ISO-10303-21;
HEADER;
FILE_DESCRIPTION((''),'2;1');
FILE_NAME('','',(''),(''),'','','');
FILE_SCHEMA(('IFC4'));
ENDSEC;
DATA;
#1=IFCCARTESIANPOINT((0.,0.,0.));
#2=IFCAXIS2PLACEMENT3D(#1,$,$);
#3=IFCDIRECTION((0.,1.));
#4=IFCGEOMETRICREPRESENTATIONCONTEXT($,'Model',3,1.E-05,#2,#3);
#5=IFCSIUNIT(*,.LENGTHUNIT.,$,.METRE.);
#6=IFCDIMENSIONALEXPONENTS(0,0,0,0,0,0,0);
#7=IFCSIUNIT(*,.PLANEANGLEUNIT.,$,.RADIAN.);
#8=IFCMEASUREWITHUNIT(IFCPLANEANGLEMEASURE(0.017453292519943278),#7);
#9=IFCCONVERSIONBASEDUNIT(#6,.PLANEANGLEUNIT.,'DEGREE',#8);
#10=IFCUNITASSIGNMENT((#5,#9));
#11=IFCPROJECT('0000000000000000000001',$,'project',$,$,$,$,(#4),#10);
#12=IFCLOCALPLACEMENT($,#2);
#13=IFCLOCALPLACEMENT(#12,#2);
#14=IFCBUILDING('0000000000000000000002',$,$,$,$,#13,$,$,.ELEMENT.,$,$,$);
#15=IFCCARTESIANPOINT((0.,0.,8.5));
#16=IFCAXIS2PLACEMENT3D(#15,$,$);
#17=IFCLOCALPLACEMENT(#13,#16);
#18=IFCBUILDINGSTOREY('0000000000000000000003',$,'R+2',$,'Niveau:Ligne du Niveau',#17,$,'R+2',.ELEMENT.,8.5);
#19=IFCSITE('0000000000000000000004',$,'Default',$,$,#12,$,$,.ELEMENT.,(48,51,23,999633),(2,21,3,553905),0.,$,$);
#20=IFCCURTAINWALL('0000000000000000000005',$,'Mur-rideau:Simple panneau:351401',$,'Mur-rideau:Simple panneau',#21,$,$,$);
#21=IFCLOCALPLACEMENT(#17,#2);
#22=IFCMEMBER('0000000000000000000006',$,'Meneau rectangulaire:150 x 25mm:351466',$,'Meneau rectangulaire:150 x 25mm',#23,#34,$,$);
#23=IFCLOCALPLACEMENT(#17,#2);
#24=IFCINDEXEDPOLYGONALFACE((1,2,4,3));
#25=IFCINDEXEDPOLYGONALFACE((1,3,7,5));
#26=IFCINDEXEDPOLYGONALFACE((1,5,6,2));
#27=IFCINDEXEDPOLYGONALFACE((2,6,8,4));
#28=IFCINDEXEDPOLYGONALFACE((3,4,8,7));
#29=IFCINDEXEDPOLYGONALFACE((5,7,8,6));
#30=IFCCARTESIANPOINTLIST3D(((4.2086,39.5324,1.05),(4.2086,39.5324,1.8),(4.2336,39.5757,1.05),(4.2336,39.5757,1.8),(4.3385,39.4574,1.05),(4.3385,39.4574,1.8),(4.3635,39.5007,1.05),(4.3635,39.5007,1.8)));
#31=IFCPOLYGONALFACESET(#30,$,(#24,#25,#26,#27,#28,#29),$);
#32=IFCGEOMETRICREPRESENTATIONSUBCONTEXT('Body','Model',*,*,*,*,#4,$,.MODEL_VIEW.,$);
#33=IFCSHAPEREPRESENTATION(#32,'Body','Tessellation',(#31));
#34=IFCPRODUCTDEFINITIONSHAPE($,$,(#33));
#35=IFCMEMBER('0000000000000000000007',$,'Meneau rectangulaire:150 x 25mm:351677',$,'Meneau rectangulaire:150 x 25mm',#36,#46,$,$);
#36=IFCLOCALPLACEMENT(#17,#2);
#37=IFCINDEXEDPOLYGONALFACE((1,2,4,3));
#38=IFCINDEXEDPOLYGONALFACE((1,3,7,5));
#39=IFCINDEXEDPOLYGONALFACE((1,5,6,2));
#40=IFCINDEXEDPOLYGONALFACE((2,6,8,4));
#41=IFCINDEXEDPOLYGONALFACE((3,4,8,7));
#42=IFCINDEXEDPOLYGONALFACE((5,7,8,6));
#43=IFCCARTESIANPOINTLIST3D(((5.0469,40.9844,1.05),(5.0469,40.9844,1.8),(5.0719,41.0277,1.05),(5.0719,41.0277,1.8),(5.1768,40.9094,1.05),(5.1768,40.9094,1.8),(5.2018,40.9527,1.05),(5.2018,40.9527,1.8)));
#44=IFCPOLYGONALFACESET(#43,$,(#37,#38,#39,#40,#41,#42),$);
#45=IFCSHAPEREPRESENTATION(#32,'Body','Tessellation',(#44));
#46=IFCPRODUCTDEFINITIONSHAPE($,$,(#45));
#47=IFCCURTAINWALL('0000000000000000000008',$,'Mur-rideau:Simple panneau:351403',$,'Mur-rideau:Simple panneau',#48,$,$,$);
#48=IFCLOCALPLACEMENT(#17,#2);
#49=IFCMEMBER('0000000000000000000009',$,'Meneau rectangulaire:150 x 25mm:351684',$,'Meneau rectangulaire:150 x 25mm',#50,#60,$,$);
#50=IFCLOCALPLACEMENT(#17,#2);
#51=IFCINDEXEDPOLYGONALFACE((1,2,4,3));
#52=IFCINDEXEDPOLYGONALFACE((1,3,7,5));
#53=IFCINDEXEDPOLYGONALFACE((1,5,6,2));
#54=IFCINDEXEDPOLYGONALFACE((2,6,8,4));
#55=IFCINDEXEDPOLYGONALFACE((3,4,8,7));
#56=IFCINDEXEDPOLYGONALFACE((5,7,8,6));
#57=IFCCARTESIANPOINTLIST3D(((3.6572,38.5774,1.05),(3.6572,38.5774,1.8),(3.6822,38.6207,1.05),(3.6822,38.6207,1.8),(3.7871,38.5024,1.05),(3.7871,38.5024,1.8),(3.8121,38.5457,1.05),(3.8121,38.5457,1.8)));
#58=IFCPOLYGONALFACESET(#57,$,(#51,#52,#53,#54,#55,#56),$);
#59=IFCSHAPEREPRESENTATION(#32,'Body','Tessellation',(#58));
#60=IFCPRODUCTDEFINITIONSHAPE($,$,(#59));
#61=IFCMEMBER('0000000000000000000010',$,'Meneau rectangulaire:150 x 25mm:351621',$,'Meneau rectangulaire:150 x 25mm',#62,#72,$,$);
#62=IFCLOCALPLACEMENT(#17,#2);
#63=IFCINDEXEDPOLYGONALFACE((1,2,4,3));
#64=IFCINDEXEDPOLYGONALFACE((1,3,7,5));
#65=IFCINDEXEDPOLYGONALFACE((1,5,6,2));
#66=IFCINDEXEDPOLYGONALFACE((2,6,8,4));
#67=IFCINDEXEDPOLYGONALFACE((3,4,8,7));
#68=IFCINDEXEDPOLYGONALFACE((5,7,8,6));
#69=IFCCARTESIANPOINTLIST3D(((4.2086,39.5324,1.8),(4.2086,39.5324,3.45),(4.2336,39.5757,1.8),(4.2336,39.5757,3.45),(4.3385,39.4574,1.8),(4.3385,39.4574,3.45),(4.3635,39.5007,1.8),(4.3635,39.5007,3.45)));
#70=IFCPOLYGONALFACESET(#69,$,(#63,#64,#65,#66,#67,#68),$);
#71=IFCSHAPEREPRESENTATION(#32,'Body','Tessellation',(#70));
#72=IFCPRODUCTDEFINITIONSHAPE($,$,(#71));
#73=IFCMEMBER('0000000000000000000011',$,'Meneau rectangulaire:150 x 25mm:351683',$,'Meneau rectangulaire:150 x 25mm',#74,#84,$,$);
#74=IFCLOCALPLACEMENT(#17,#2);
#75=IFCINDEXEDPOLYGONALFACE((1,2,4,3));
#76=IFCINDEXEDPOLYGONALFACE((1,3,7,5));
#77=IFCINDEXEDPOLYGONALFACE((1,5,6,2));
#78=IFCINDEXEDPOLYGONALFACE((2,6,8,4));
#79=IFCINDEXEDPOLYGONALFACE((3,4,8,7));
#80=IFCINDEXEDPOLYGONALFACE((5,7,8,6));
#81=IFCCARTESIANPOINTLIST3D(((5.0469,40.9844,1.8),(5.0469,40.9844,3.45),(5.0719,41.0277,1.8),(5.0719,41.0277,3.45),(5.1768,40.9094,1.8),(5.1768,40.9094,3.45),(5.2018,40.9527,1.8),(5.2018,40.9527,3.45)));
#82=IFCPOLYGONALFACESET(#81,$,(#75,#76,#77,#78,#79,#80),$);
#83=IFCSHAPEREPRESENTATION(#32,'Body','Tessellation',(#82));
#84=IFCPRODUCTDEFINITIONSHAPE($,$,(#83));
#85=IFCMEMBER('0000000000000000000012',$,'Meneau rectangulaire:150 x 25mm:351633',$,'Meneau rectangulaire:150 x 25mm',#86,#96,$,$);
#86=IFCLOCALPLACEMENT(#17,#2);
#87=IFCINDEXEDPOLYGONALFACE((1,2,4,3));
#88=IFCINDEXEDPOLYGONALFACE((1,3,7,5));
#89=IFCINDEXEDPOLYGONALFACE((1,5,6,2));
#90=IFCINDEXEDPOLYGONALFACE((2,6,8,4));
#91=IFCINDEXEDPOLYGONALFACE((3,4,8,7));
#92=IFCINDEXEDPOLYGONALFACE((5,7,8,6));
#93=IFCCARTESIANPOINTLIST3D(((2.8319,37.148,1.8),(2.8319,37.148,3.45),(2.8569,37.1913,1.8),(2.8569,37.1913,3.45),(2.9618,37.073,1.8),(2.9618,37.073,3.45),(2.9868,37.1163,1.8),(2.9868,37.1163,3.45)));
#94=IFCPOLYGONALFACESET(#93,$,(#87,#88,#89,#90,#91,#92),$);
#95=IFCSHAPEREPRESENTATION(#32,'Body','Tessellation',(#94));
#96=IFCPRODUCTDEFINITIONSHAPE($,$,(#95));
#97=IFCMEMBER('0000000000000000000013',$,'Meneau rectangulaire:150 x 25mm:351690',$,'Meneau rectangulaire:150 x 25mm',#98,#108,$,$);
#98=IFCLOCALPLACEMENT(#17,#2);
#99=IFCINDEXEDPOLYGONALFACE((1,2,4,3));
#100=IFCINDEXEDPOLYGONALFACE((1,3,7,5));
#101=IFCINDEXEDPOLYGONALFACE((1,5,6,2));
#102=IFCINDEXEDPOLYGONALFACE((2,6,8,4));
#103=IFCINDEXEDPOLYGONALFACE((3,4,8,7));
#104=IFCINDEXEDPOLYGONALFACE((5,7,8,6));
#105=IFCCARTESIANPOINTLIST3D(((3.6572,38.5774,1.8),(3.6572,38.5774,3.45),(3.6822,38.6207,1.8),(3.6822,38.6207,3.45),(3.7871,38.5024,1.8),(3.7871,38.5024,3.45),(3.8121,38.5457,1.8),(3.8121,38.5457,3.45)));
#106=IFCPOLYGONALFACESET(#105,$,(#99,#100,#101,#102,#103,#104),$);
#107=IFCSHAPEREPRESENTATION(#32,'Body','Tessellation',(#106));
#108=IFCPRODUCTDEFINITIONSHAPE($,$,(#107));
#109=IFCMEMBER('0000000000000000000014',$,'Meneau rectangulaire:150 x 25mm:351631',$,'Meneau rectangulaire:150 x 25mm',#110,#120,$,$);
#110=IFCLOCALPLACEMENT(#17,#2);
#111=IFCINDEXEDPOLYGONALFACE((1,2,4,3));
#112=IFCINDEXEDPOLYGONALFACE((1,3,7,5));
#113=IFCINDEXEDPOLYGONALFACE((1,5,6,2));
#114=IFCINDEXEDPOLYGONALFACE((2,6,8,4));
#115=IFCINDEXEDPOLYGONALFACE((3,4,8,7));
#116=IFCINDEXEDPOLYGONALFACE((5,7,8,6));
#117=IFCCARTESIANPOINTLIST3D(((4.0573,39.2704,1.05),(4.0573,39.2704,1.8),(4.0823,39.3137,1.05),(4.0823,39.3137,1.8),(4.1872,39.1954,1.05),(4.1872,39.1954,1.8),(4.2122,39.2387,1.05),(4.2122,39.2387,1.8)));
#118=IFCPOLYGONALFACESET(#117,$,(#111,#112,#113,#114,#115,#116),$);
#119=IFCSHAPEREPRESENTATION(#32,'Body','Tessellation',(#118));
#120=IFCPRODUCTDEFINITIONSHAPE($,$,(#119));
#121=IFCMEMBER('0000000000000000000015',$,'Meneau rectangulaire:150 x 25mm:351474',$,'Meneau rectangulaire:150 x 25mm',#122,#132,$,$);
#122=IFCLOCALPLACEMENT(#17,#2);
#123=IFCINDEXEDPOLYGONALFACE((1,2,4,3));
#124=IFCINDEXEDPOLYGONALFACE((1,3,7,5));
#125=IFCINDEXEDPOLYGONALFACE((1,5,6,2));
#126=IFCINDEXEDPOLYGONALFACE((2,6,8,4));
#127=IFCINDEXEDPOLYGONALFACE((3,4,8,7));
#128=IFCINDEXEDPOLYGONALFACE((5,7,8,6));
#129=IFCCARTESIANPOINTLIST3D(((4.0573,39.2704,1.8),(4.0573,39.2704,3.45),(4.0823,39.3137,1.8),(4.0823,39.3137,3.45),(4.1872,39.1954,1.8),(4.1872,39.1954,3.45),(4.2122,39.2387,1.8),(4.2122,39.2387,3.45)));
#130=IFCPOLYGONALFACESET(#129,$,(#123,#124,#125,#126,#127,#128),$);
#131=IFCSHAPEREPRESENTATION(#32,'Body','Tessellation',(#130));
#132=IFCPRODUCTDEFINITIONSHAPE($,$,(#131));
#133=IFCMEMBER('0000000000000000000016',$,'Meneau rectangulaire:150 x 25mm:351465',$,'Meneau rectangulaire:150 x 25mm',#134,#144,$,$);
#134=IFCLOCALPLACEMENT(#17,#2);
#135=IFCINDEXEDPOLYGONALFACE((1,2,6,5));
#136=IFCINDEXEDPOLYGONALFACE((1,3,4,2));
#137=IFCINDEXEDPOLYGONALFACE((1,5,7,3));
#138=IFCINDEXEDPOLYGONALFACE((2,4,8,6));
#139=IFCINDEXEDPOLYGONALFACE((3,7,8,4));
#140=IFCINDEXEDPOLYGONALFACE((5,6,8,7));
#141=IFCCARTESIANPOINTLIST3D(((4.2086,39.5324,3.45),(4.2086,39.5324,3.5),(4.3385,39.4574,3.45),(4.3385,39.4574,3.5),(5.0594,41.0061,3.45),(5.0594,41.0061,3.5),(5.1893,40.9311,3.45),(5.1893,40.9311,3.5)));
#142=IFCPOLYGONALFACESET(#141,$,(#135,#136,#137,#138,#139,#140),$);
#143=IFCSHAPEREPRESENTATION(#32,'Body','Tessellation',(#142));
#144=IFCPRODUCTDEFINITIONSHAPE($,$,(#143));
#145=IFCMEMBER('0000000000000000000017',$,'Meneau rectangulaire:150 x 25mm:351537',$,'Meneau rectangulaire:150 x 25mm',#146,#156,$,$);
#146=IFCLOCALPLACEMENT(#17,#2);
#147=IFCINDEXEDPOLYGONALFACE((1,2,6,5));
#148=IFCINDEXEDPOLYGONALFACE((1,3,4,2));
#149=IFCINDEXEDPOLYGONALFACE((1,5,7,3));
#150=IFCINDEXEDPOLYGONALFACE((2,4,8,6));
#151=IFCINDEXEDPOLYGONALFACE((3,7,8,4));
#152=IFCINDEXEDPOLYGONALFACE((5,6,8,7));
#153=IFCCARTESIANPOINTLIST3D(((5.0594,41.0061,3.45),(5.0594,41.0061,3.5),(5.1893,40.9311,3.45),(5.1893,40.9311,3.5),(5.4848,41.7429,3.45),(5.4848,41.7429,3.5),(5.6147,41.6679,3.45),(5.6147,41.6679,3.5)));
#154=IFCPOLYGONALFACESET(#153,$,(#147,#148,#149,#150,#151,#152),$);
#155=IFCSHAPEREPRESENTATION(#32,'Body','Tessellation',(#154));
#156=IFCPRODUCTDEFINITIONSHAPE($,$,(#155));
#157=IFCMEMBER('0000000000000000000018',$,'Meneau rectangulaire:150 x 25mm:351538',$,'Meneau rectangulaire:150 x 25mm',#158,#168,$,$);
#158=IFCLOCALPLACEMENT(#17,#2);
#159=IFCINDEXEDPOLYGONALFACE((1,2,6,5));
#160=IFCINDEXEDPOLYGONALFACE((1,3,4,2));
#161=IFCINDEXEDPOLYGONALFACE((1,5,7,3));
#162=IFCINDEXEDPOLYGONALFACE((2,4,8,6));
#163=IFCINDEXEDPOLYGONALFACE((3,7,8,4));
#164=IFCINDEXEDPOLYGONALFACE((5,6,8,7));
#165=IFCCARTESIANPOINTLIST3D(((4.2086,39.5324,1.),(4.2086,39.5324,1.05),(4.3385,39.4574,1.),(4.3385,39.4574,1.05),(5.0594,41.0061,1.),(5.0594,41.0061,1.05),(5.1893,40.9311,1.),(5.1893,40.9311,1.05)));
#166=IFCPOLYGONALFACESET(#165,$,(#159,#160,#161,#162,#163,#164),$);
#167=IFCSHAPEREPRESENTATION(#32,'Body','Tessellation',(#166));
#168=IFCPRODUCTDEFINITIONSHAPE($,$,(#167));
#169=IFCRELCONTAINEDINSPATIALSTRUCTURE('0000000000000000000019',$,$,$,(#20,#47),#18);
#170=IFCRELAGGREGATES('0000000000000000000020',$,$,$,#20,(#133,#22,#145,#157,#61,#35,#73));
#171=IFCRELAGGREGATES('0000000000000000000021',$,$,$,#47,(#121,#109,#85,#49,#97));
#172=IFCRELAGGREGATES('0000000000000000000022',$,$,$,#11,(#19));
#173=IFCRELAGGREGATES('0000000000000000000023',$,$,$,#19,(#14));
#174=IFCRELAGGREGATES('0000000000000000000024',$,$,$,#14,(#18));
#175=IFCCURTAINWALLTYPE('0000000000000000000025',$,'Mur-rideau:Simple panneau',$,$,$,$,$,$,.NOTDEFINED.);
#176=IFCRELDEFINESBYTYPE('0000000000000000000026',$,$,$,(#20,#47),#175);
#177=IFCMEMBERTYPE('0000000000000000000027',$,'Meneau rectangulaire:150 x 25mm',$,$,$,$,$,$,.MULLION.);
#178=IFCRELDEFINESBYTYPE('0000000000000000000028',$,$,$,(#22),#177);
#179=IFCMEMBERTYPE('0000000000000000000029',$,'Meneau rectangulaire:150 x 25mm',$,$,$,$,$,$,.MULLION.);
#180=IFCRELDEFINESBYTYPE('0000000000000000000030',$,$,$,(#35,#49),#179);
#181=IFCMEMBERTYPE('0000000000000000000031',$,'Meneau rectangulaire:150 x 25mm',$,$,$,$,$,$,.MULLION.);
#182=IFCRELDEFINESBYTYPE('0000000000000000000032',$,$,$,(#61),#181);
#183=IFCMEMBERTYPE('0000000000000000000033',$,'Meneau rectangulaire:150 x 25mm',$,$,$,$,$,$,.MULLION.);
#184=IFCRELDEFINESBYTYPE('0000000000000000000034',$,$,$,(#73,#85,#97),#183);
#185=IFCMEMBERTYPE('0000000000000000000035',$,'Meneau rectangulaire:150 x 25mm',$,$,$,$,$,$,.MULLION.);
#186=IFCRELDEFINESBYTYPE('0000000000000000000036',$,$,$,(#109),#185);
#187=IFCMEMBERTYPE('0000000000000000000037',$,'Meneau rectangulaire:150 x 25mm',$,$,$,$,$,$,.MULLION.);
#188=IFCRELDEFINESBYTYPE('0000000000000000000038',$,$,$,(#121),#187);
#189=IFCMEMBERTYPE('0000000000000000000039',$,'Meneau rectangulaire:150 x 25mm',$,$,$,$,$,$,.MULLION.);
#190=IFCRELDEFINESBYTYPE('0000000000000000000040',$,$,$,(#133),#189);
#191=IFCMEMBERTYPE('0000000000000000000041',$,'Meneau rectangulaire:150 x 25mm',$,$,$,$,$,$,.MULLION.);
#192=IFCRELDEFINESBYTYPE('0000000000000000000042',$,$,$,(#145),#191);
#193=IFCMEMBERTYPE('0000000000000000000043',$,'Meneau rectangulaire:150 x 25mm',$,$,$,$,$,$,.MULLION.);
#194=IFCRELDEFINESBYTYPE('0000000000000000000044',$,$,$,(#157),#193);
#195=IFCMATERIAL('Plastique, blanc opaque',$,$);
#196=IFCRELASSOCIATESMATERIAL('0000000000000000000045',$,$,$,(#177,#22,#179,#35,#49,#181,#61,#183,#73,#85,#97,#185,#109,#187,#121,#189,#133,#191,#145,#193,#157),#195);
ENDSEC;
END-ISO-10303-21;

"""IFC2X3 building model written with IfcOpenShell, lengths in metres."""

from ifc_helpers import new_model, entity, si_unit, converted_unit, direction, frame, frame_2d, origin, origin_2d_with_axis, place, context, subcontext, project, spatial, rectangle, extrude, source, transform, mapped, material, type_object, type_shapes, element, aggregate, save


model = new_model("IFC2X3")

# Units and contexts
model_context = context("Model", 3, precision=1e-05, world=origin(), true_north=direction((0.0, 1.0)))
body_context = subcontext(model_context, "Body", "Model", "MODEL_VIEW")
ifc_project = project(units=[si_unit("LENGTHUNIT", "METRE"), converted_unit("PLANEANGLEUNIT", "DEGREE", entity("IfcPlaneAngleMeasure", 0.017453292519943278), si_unit("PLANEANGLEUNIT", "RADIAN"), dimensions=[0, 0, 0, 0, 0, 0, 0])], contexts=[model_context])

# Site, building, storey
site_placement = place(None, origin())
site = spatial("IfcSite", under=ifc_project, at=site_placement, Name="Default", CompositionType="ELEMENT", RefLatitude=(48, 51, 23, 999633), RefLongitude=(2, 21, 3, 553905), RefElevation=0.0)
building_placement = place(site_placement, origin())
building = spatial("IfcBuilding", under=site, at=building_placement, CompositionType="ELEMENT")
storey_placement = place(building_placement, frame((0.0, 0.0, 8.5)))
storey = spatial("IfcBuildingStorey", under=building, at=storey_placement, Name="R+2", ObjectType="Niveau:Ligne du Niveau", LongName="R+2", CompositionType="ELEMENT", Elevation=8.5)

# Curtain wall, members
curtain_wall_type = type_object("IfcCurtainWallType", Name="Mur-rideau:Simple panneau", PredefinedType="NOTDEFINED")
curtain_wall_1_placement = place(storey_placement, frame((0.0, 0.0, -8.5)))
curtain_wall_1 = element("IfcCurtainWall", 1, at=curtain_wall_1_placement, inside=storey, type_object=curtain_wall_type, Name="Mur-rideau:Simple panneau:351401", ObjectType="Mur-rideau:Simple panneau")
ifc_material_1 = material(Name="Plastique, blanc opaque")
member_type_1 = type_object("IfcMemberType", Name="Meneau rectangulaire:150 x 25mm", PredefinedType="MULLION", material=ifc_material_1)
shared_shape_1 = source(origin(), body_context, "Body", "SweptSolid", [
    extrude(rectangle(XDim=0.05, YDim=0.15, at=origin_2d_with_axis()), frame((-0.025, 0.0, -0.75), z_axis=(0.0, 0.0, 1.0), x_axis=(-1.0, 0.0, 0.0)), (0.0, 0.0, 1.0), 0.75),
])
type_shapes(member_type_1, [shared_shape_1])
member_1_placement = place(curtain_wall_1_placement, frame((4.2735, 39.4949, 9.55), z_axis=(0.0, 0.0, -1.0), x_axis=(-0.5, -0.866025, 0.0)))
member_1 = element("IfcMember", 2, at=member_1_placement, type_object=member_type_1, material=ifc_material_1, Name="Meneau rectangulaire:150 x 25mm:351466", ObjectType="Meneau rectangulaire:150 x 25mm", context=body_context, shape_type="MappedRepresentation", body=[
    mapped(shared_shape_1, transform((0.0, 0.0, 0.0), scale=1.0)),
])
member_type_2 = type_object("IfcMemberType", Name="Meneau rectangulaire:150 x 25mm", PredefinedType="MULLION", material=ifc_material_1)
shared_shape_2 = source(origin(), body_context, "Body", "SweptSolid", [
    extrude(rectangle(XDim=0.05, YDim=0.15, at=origin_2d_with_axis()), frame((0.0, 0.0, -0.75), z_axis=(0.0, 0.0, 1.0), x_axis=(-1.0, 0.0, 0.0)), (0.0, 0.0, 1.0), 0.75),
])
type_shapes(member_type_2, [shared_shape_2])
member_2_placement = place(curtain_wall_1_placement, frame((5.1244, 40.9686, 9.55), z_axis=(0.0, 0.0, -1.0), x_axis=(-0.5, -0.866025, 0.0)))
member_2 = element("IfcMember", 3, at=member_2_placement, type_object=member_type_2, material=ifc_material_1, Name="Meneau rectangulaire:150 x 25mm:351677", ObjectType="Meneau rectangulaire:150 x 25mm", context=body_context, shape_type="MappedRepresentation", body=[
    mapped(shared_shape_2, transform((0.0, 0.0, 0.0), scale=1.0)),
])

# Curtain wall, member
curtain_wall_2_placement = place(storey_placement, frame((0.0, 0.0, -8.5)))
curtain_wall_2 = element("IfcCurtainWall", 4, at=curtain_wall_2_placement, inside=storey, type_object=curtain_wall_type, Name="Mur-rideau:Simple panneau:351403", ObjectType="Mur-rideau:Simple panneau")
member_3_placement = place(curtain_wall_2_placement, frame((3.7347, 38.5615, 9.55), z_axis=(0.0, 0.0, -1.0), x_axis=(-0.5, -0.866025, 0.0)))
member_3 = element("IfcMember", 5, at=member_3_placement, type_object=member_type_2, material=ifc_material_1, Name="Meneau rectangulaire:150 x 25mm:351684", ObjectType="Meneau rectangulaire:150 x 25mm", context=body_context, shape_type="MappedRepresentation", body=[
    mapped(shared_shape_2, transform((0.0, 0.0, 0.0), scale=1.0)),
])

# Members
member_type_3 = type_object("IfcMemberType", Name="Meneau rectangulaire:150 x 25mm", PredefinedType="MULLION", material=ifc_material_1)
shared_shape_3 = source(origin(), body_context, "Body", "SweptSolid", [
    extrude(rectangle(XDim=0.05, YDim=0.15, at=origin_2d_with_axis()), frame((-0.025, 0.0, -1.65), z_axis=(0.0, 0.0, 1.0), x_axis=(-1.0, 0.0, 0.0)), (0.0, 0.0, 1.0), 1.65),
])
type_shapes(member_type_3, [shared_shape_3])
member_4_placement = place(curtain_wall_1_placement, frame((4.2735, 39.4949, 10.3), z_axis=(0.0, 0.0, -1.0), x_axis=(-0.5, -0.866025, 0.0)))
member_4 = element("IfcMember", 6, at=member_4_placement, type_object=member_type_3, material=ifc_material_1, Name="Meneau rectangulaire:150 x 25mm:351621", ObjectType="Meneau rectangulaire:150 x 25mm", context=body_context, shape_type="MappedRepresentation", body=[
    mapped(shared_shape_3, transform((0.0, 0.0, 0.0), scale=1.0)),
])
member_type_4 = type_object("IfcMemberType", Name="Meneau rectangulaire:150 x 25mm", PredefinedType="MULLION", material=ifc_material_1)
shared_shape_4 = source(origin(), body_context, "Body", "SweptSolid", [
    extrude(rectangle(XDim=0.05, YDim=0.15, at=origin_2d_with_axis()), frame((0.0, 0.0, -1.65), z_axis=(0.0, 0.0, 1.0), x_axis=(-1.0, 0.0, 0.0)), (0.0, 0.0, 1.0), 1.65),
])
type_shapes(member_type_4, [shared_shape_4])
member_5_placement = place(curtain_wall_1_placement, frame((5.1244, 40.9686, 10.3), z_axis=(0.0, 0.0, -1.0), x_axis=(-0.5, -0.866025, 0.0)))
member_5 = element("IfcMember", 7, at=member_5_placement, type_object=member_type_4, material=ifc_material_1, Name="Meneau rectangulaire:150 x 25mm:351683", ObjectType="Meneau rectangulaire:150 x 25mm", context=body_context, shape_type="MappedRepresentation", body=[
    mapped(shared_shape_4, transform((0.0, 0.0, 0.0), scale=1.0)),
])
member_6_placement = place(curtain_wall_2_placement, frame((2.9094, 37.1322, 10.3), z_axis=(0.0, 0.0, -1.0), x_axis=(-0.5, -0.866025, 0.0)))
member_6 = element("IfcMember", 8, at=member_6_placement, type_object=member_type_4, material=ifc_material_1, Name="Meneau rectangulaire:150 x 25mm:351633", ObjectType="Meneau rectangulaire:150 x 25mm", context=body_context, shape_type="MappedRepresentation", body=[
    mapped(shared_shape_4, transform((0.0, 0.0, 0.0), scale=1.0)),
])
member_7_placement = place(curtain_wall_2_placement, frame((3.7347, 38.5615, 10.3), z_axis=(0.0, 0.0, -1.0), x_axis=(-0.5, -0.866025, 0.0)))
member_7 = element("IfcMember", 9, at=member_7_placement, type_object=member_type_4, material=ifc_material_1, Name="Meneau rectangulaire:150 x 25mm:351690", ObjectType="Meneau rectangulaire:150 x 25mm", context=body_context, shape_type="MappedRepresentation", body=[
    mapped(shared_shape_4, transform((0.0, 0.0, 0.0), scale=1.0)),
])
member_type_5 = type_object("IfcMemberType", Name="Meneau rectangulaire:150 x 25mm", PredefinedType="MULLION", material=ifc_material_1)
shared_shape_5 = source(origin(), body_context, "Body", "SweptSolid", [
    extrude(rectangle(XDim=0.05, YDim=0.15, at=origin_2d_with_axis()), frame((-0.025, 0.0, -0.75), z_axis=(0.0, 0.0, 1.0), x_axis=(-1.0, 0.0, 0.0)), (0.0, 0.0, 1.0), 0.75),
])
type_shapes(member_type_5, [shared_shape_5])
member_8_placement = place(curtain_wall_2_placement, frame((4.1473, 39.2762, 10.3), z_axis=(0.0, 0.0, 1.0), x_axis=(0.5, 0.866025, 0.0)))
member_8 = element("IfcMember", 10, at=member_8_placement, type_object=member_type_5, material=ifc_material_1, Name="Meneau rectangulaire:150 x 25mm:351631", ObjectType="Meneau rectangulaire:150 x 25mm", context=body_context, shape_type="MappedRepresentation", body=[
    mapped(shared_shape_5, transform((0.0, 0.0, 0.0), scale=1.0)),
])
member_type_6 = type_object("IfcMemberType", Name="Meneau rectangulaire:150 x 25mm", PredefinedType="MULLION", material=ifc_material_1)
shared_shape_6 = source(origin(), body_context, "Body", "SweptSolid", [
    extrude(rectangle(XDim=0.05, YDim=0.15, at=origin_2d_with_axis()), frame((-0.025, 0.0, -1.65), z_axis=(0.0, 0.0, 1.0), x_axis=(-1.0, 0.0, 0.0)), (0.0, 0.0, 1.0), 1.65),
])
type_shapes(member_type_6, [shared_shape_6])
member_9_placement = place(curtain_wall_2_placement, frame((4.1473, 39.2762, 11.95), z_axis=(0.0, 0.0, 1.0), x_axis=(0.5, 0.866025, 0.0)))
member_9 = element("IfcMember", 11, at=member_9_placement, type_object=member_type_6, material=ifc_material_1, Name="Meneau rectangulaire:150 x 25mm:351474", ObjectType="Meneau rectangulaire:150 x 25mm", context=body_context, shape_type="MappedRepresentation", body=[
    mapped(shared_shape_6, transform((0.0, 0.0, 0.0), scale=1.0)),
])
member_type_7 = type_object("IfcMemberType", Name="Meneau rectangulaire:150 x 25mm", PredefinedType="MULLION", material=ifc_material_1)
shared_shape_7 = source(origin(), body_context, "Body", "SweptSolid", [
    extrude(rectangle(XDim=0.05, YDim=0.15, at=frame_2d((0.0, 0.0), x_axis=(1.0, 0.0))), frame((-0.025, 0.0, -1.7017), z_axis=(0.0, 0.0, 1.0), x_axis=(-1.0, 0.0, 0.0)), (0.0, 0.0, 1.0), 1.7017),
])
type_shapes(member_type_7, [shared_shape_7])
member_10_placement = place(curtain_wall_1_placement, frame((4.2735, 39.4949, 12.0), z_axis=(-0.5, -0.866025, 0.0), x_axis=(0.0, 0.0, 1.0)))
member_10 = element("IfcMember", 12, at=member_10_placement, type_object=member_type_7, material=ifc_material_1, Name="Meneau rectangulaire:150 x 25mm:351465", ObjectType="Meneau rectangulaire:150 x 25mm", context=body_context, shape_type="MappedRepresentation", body=[
    mapped(shared_shape_7, transform((0.0, 0.0, 0.0), scale=1.0)),
])
member_type_8 = type_object("IfcMemberType", Name="Meneau rectangulaire:150 x 25mm", PredefinedType="MULLION", material=ifc_material_1)
shared_shape_8 = source(origin(), body_context, "Body", "SweptSolid", [
    extrude(rectangle(XDim=0.05, YDim=0.15, at=origin_2d_with_axis()), frame((-0.025, 0.0, -0.8508), z_axis=(0.0, 0.0, 1.0), x_axis=(-1.0, 0.0, 0.0)), (0.0, 0.0, 1.0), 0.8508),
])
type_shapes(member_type_8, [shared_shape_8])
member_11_placement = place(curtain_wall_1_placement, frame((5.1244, 40.9686, 12.0), z_axis=(-0.5, -0.866025, 0.0), x_axis=(0.0, 0.0, 1.0)))
member_11 = element("IfcMember", 13, at=member_11_placement, type_object=member_type_8, material=ifc_material_1, Name="Meneau rectangulaire:150 x 25mm:351537", ObjectType="Meneau rectangulaire:150 x 25mm", context=body_context, shape_type="MappedRepresentation", body=[
    mapped(shared_shape_8, transform((0.0, 0.0, 0.0), scale=1.0)),
])
member_type_9 = type_object("IfcMemberType", Name="Meneau rectangulaire:150 x 25mm", PredefinedType="MULLION", material=ifc_material_1)
shared_shape_9 = source(origin(), body_context, "Body", "SweptSolid", [
    extrude(rectangle(XDim=0.05, YDim=0.15, at=origin_2d_with_axis()), frame((-0.025, 0.0, -1.7017), z_axis=(0.0, 0.0, 1.0), x_axis=(-1.0, 0.0, 0.0)), (0.0, 0.0, 1.0), 1.7017),
])
type_shapes(member_type_9, [shared_shape_9])
member_12_placement = place(curtain_wall_1_placement, frame((5.1244, 40.9686, 9.5), z_axis=(0.5, 0.866025, 0.0), x_axis=(0.0, 0.0, -1.0)))
member_12 = element("IfcMember", 14, at=member_12_placement, type_object=member_type_9, material=ifc_material_1, Name="Meneau rectangulaire:150 x 25mm:351538", ObjectType="Meneau rectangulaire:150 x 25mm", context=body_context, shape_type="MappedRepresentation", body=[
    mapped(shared_shape_9, transform((0.0, 0.0, 0.0), scale=1.0)),
])

aggregate(curtain_wall_1, [member_10, member_1, member_11, member_12, member_4, member_2, member_5])
aggregate(curtain_wall_2, [member_9, member_8, member_6, member_3, member_7])

save(model, "model.ifc")
